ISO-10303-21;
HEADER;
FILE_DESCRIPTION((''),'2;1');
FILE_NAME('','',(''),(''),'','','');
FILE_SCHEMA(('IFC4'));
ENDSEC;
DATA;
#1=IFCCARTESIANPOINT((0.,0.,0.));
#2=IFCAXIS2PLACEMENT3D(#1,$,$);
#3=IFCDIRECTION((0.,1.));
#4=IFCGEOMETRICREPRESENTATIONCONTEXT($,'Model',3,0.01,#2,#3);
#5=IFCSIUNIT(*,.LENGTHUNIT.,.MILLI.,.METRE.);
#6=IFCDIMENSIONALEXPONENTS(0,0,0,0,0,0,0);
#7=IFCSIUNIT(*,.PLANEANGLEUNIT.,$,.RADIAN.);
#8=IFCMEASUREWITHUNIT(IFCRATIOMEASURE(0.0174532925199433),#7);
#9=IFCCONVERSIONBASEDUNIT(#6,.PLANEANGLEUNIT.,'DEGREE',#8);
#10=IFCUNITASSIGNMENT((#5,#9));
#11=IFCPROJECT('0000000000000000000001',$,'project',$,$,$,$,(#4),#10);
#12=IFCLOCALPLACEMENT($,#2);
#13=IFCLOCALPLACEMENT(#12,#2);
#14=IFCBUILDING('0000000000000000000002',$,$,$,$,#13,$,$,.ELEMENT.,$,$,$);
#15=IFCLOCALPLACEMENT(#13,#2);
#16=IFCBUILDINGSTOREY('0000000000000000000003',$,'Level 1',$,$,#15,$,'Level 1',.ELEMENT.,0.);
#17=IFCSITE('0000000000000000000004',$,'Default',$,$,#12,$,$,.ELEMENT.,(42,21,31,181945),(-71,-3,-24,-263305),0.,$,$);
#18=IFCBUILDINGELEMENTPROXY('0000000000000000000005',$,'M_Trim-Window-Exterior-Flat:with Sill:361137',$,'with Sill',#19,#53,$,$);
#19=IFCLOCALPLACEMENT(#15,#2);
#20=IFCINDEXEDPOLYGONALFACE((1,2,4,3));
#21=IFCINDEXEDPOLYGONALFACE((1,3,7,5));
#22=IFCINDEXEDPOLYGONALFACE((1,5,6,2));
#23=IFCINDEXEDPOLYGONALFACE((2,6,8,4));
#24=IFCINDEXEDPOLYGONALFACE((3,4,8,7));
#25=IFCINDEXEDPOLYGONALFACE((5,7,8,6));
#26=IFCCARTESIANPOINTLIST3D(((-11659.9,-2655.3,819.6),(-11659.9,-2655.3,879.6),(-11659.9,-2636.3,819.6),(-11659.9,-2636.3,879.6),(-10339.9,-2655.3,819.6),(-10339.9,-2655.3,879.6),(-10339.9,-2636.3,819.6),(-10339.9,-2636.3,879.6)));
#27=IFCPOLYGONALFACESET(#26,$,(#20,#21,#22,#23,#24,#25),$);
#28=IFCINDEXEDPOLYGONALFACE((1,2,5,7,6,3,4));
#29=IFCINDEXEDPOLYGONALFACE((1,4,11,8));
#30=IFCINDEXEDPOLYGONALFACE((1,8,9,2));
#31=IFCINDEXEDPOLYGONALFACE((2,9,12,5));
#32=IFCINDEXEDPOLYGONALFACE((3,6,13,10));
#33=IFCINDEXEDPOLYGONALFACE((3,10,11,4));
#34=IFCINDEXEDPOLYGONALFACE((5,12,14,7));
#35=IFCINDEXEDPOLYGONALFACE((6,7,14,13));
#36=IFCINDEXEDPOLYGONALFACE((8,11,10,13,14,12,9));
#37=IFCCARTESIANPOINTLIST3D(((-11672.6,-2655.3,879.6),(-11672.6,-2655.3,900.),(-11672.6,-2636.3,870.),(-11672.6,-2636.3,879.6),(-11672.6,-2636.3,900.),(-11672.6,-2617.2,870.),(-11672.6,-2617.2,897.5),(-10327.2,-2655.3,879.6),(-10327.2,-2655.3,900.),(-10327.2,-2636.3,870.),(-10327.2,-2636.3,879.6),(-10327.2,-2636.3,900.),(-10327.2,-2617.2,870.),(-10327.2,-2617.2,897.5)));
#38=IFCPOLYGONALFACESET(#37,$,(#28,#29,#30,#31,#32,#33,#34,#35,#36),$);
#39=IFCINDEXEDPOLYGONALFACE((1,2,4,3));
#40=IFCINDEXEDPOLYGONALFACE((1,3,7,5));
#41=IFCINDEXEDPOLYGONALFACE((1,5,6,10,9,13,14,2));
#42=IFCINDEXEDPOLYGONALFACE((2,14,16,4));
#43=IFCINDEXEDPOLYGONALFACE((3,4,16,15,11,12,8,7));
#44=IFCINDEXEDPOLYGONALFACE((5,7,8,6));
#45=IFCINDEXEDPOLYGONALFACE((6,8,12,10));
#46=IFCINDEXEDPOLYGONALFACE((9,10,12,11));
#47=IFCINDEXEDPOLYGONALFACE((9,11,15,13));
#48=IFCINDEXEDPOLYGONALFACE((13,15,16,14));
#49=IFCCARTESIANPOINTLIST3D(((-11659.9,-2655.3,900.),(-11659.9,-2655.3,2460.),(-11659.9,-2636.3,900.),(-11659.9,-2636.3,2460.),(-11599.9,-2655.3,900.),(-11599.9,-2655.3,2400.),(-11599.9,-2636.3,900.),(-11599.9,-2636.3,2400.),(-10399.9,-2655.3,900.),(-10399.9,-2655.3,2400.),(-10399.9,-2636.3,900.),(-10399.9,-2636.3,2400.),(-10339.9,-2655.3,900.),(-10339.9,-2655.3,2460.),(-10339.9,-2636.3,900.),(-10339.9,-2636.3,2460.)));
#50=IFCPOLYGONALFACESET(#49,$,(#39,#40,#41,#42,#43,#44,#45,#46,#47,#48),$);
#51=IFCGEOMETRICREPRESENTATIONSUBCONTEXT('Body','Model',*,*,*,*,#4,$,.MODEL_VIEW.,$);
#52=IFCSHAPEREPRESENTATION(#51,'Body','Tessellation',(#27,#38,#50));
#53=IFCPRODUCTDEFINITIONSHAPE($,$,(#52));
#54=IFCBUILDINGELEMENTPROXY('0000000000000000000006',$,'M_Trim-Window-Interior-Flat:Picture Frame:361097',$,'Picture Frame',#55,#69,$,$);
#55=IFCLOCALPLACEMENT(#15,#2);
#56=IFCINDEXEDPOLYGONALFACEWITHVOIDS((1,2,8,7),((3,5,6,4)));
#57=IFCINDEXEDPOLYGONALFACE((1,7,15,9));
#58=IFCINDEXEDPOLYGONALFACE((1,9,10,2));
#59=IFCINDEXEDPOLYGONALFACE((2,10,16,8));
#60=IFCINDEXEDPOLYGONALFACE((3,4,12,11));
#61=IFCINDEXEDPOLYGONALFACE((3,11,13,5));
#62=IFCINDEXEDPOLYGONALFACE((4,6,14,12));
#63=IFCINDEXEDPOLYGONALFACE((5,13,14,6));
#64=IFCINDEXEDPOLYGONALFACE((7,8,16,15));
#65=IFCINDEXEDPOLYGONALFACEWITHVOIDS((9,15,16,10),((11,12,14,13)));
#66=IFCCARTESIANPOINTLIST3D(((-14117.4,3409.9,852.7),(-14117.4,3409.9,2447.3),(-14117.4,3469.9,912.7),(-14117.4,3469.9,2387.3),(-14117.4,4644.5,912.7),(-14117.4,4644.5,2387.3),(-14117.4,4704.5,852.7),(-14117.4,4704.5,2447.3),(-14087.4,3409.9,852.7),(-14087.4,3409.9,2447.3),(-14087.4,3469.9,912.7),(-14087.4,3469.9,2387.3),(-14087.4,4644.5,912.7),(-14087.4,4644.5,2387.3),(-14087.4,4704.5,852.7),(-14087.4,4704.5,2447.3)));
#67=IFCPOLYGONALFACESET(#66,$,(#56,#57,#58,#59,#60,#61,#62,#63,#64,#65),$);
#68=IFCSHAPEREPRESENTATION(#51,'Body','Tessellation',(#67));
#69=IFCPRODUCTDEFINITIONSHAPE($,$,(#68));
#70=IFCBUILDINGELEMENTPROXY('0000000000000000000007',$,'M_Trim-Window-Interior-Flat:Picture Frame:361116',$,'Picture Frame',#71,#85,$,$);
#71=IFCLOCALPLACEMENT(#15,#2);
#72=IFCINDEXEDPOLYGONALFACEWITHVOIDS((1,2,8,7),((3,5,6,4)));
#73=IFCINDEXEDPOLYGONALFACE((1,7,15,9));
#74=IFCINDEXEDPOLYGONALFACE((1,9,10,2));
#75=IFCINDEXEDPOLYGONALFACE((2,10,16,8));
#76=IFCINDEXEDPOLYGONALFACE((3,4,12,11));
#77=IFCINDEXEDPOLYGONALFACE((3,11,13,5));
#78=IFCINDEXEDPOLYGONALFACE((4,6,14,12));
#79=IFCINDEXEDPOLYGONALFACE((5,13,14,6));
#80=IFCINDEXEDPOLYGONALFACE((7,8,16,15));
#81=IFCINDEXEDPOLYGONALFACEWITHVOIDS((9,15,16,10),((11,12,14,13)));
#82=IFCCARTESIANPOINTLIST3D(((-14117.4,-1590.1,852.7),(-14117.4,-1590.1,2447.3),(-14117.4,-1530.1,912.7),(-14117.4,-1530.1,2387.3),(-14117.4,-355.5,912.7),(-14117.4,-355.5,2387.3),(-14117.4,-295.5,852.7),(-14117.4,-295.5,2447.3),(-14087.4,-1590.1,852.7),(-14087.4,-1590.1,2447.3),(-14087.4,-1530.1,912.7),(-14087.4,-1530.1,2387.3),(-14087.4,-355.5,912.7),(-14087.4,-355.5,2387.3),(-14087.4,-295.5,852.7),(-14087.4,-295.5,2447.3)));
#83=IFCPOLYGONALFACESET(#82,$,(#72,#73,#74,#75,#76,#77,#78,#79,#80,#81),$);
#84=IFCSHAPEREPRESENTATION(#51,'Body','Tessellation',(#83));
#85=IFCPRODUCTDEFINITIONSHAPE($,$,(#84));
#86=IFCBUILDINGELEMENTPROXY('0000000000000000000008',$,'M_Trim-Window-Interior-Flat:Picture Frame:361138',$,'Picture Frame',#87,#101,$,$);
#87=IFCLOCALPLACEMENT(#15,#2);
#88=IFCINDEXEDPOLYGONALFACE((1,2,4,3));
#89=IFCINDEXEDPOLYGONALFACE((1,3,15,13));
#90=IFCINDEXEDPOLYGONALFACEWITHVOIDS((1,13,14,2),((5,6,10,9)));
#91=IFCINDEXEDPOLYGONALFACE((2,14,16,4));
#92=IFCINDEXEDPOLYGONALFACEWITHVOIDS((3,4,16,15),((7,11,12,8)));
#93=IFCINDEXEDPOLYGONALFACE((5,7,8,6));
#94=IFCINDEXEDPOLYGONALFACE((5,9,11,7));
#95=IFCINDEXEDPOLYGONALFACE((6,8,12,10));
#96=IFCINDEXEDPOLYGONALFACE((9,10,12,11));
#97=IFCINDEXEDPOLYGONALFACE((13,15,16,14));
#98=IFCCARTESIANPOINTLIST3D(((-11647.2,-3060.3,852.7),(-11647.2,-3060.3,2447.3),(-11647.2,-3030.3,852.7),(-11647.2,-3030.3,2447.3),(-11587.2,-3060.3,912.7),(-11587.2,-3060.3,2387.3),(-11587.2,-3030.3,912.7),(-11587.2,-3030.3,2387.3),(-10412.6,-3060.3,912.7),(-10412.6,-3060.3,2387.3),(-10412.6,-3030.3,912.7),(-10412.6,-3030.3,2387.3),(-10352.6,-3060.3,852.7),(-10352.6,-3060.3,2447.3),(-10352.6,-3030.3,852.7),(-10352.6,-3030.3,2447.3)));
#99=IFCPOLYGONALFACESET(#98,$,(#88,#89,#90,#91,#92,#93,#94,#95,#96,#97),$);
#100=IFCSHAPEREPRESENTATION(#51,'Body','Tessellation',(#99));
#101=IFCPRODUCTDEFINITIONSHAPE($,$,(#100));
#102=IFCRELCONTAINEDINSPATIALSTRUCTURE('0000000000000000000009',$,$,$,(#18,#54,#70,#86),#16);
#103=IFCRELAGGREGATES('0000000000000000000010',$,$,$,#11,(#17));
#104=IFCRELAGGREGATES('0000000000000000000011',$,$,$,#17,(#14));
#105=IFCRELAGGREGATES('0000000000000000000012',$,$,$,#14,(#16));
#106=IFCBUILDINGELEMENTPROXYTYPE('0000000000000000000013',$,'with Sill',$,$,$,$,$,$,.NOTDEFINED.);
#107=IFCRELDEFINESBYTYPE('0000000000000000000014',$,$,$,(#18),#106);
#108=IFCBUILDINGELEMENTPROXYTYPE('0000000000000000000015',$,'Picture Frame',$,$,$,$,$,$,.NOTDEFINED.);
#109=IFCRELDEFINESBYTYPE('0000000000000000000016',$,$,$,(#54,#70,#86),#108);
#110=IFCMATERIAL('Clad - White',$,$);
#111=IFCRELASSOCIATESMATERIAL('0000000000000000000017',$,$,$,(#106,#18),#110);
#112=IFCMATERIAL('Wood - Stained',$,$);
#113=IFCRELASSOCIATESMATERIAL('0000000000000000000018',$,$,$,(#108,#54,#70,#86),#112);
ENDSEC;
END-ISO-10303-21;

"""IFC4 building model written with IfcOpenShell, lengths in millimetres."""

from ifc_helpers import new_model, entity, si_unit, converted_unit, direction, frame, frame_2d, origin, place, context, subcontext, project, spatial, polyline, rectangle, outline, extrude, source, transform, mapped, material, type_object, type_shapes, element, save


model = new_model("IFC4")

# Units and contexts
model_context = context("Model", 3, precision=0.01, world=origin(), true_north=direction((0.0, 1.0)))
body_context = subcontext(model_context, "Body", "Model", "MODEL_VIEW")
ifc_project = project(units=[si_unit("LENGTHUNIT", "METRE", prefix="MILLI"), converted_unit("PLANEANGLEUNIT", "DEGREE", entity("IfcRatioMeasure", 0.0174532925199433), si_unit("PLANEANGLEUNIT", "RADIAN"), dimensions=[0, 0, 0, 0, 0, 0, 0])], contexts=[model_context])

# Site, building, storey
site_placement = place(None, origin())
site = spatial("IfcSite", under=ifc_project, at=site_placement, Name="Default", CompositionType="ELEMENT", RefLatitude=(42, 21, 31, 181945), RefLongitude=(-71, -3, -24, -263305), RefElevation=0.0)
building_placement = place(site_placement, origin())
building = spatial("IfcBuilding", under=site, at=building_placement, CompositionType="ELEMENT")
storey_placement = place(building_placement, origin())
storey = spatial("IfcBuildingStorey", under=building, at=storey_placement, Name="Level 1", LongName="Level 1", CompositionType="ELEMENT", Elevation=0.0)

# Building element proxies
ifc_material_1 = material(Name="Clad - White")
ifc_material_2 = material(Name="Wood - Stained")
building_element_proxy_type_1 = type_object("IfcBuildingElementProxyType", Name="with Sill", PredefinedType="NOTDEFINED", material=ifc_material_1)
shared_shape_1 = source(origin(), body_context, "Body", "SweptSolid", [
    extrude(rectangle(XDim=1320.0, YDim=60.0, at=frame_2d((0.0, 0.0), x_axis=(1.0, 0.0))), frame((0.0, -1550.4, 0.0), z_axis=(0.0, 0.0, 1.0), x_axis=(-1.0, 0.0, 0.0)), (0.0, 0.0, 1.0), 19.1),
    extrude(outline(polyline([(-19.0, -15.2), (0.0, -15.2), (0.0, -5.7), (19.0, -5.7), (19.0, 14.8), (0.0, 14.8), (-19.0, 12.3), (-19.0, -15.2)])), frame((-672.7, -1514.8, 19.0), z_axis=(1.0, 0.0, 0.0), x_axis=(0.0, 0.0, -1.0)), (0.0, 0.0, 1.0), 1345.4),
    extrude(outline(polyline([(-795.0, -660.0), (765.0, -660.0), (765.0, -600.0), (-735.0, -600.0), (-735.0, 600.0), (765.0, 600.0), (765.0, 660.0), (-795.0, 660.0), (-795.0, -660.0)])), frame((0.0, -735.0, 0.0), z_axis=(0.0, 0.0, 1.0), x_axis=(0.0, -1.0, 0.0)), (0.0, 0.0, 1.0), 19.1),
])
type_shapes(building_element_proxy_type_1, [shared_shape_1])
for number, where, z_axis, x_axis, name in (
    (1, (-10999.9, -2655.3, 2400.0), (0.0, 1.0, 0.0), (-1.0, 0.0, 0.0), "M_Trim-Window-Exterior-Flat:with Sill:361137"),
):
    element("IfcBuildingElementProxy", number, at=place(storey_placement, frame(where, z_axis=z_axis, x_axis=x_axis)), inside=storey, type_object=building_element_proxy_type_1, material=ifc_material_1, Name=name, ObjectType="with Sill", context=body_context, shape_type="MappedRepresentation", body=[
        mapped(shared_shape_1, transform((0.0, 0.0, 0.0), scale=1.0)),
    ])
building_element_proxy_type_2 = type_object("IfcBuildingElementProxyType", Name="Picture Frame", PredefinedType="NOTDEFINED", material=ifc_material_2)
shared_shape_2 = source(origin(), body_context, "Body", "SweptSolid", [
    extrude(outline(polyline([(-647.3, -797.3), (647.3, -797.3), (647.3, 797.3), (-647.3, 797.3), (-647.3, -797.3)]), holes=[polyline([(-587.3, -737.3), (-587.3, 737.3), (587.3, 737.3), (587.3, -737.3), (-587.3, -737.3)])]), frame((0.0, -750.0, 0.0), z_axis=(0.0, 0.0, 1.0), x_axis=(-1.0, 0.0, 0.0)), (0.0, 0.0, 1.0), 30.0),
])
type_shapes(building_element_proxy_type_2, [shared_shape_2])
for number, where, z_axis, x_axis, name in (
    (2, (-14087.4, 4057.2, 2400.0), (-1.0, 0.0, 0.0), (0.0, -1.0, 0.0), "M_Trim-Window-Interior-Flat:Picture Frame:361097"),
    (3, (-14087.4, -942.8, 2400.0), (-1.0, 0.0, 0.0), (0.0, -1.0, 0.0), "M_Trim-Window-Interior-Flat:Picture Frame:361116"),
    (4, (-10999.9, -3030.3, 2400.0), (0.0, -1.0, 0.0), (1.0, 0.0, 0.0), "M_Trim-Window-Interior-Flat:Picture Frame:361138"),
):
    element("IfcBuildingElementProxy", number, at=place(storey_placement, frame(where, z_axis=z_axis, x_axis=x_axis)), inside=storey, type_object=building_element_proxy_type_2, material=ifc_material_2, Name=name, ObjectType="Picture Frame", context=body_context, shape_type="MappedRepresentation", body=[
        mapped(shared_shape_2, transform((0.0, 0.0, 0.0), scale=1.0)),
    ])

save(model, "model.ifc")
